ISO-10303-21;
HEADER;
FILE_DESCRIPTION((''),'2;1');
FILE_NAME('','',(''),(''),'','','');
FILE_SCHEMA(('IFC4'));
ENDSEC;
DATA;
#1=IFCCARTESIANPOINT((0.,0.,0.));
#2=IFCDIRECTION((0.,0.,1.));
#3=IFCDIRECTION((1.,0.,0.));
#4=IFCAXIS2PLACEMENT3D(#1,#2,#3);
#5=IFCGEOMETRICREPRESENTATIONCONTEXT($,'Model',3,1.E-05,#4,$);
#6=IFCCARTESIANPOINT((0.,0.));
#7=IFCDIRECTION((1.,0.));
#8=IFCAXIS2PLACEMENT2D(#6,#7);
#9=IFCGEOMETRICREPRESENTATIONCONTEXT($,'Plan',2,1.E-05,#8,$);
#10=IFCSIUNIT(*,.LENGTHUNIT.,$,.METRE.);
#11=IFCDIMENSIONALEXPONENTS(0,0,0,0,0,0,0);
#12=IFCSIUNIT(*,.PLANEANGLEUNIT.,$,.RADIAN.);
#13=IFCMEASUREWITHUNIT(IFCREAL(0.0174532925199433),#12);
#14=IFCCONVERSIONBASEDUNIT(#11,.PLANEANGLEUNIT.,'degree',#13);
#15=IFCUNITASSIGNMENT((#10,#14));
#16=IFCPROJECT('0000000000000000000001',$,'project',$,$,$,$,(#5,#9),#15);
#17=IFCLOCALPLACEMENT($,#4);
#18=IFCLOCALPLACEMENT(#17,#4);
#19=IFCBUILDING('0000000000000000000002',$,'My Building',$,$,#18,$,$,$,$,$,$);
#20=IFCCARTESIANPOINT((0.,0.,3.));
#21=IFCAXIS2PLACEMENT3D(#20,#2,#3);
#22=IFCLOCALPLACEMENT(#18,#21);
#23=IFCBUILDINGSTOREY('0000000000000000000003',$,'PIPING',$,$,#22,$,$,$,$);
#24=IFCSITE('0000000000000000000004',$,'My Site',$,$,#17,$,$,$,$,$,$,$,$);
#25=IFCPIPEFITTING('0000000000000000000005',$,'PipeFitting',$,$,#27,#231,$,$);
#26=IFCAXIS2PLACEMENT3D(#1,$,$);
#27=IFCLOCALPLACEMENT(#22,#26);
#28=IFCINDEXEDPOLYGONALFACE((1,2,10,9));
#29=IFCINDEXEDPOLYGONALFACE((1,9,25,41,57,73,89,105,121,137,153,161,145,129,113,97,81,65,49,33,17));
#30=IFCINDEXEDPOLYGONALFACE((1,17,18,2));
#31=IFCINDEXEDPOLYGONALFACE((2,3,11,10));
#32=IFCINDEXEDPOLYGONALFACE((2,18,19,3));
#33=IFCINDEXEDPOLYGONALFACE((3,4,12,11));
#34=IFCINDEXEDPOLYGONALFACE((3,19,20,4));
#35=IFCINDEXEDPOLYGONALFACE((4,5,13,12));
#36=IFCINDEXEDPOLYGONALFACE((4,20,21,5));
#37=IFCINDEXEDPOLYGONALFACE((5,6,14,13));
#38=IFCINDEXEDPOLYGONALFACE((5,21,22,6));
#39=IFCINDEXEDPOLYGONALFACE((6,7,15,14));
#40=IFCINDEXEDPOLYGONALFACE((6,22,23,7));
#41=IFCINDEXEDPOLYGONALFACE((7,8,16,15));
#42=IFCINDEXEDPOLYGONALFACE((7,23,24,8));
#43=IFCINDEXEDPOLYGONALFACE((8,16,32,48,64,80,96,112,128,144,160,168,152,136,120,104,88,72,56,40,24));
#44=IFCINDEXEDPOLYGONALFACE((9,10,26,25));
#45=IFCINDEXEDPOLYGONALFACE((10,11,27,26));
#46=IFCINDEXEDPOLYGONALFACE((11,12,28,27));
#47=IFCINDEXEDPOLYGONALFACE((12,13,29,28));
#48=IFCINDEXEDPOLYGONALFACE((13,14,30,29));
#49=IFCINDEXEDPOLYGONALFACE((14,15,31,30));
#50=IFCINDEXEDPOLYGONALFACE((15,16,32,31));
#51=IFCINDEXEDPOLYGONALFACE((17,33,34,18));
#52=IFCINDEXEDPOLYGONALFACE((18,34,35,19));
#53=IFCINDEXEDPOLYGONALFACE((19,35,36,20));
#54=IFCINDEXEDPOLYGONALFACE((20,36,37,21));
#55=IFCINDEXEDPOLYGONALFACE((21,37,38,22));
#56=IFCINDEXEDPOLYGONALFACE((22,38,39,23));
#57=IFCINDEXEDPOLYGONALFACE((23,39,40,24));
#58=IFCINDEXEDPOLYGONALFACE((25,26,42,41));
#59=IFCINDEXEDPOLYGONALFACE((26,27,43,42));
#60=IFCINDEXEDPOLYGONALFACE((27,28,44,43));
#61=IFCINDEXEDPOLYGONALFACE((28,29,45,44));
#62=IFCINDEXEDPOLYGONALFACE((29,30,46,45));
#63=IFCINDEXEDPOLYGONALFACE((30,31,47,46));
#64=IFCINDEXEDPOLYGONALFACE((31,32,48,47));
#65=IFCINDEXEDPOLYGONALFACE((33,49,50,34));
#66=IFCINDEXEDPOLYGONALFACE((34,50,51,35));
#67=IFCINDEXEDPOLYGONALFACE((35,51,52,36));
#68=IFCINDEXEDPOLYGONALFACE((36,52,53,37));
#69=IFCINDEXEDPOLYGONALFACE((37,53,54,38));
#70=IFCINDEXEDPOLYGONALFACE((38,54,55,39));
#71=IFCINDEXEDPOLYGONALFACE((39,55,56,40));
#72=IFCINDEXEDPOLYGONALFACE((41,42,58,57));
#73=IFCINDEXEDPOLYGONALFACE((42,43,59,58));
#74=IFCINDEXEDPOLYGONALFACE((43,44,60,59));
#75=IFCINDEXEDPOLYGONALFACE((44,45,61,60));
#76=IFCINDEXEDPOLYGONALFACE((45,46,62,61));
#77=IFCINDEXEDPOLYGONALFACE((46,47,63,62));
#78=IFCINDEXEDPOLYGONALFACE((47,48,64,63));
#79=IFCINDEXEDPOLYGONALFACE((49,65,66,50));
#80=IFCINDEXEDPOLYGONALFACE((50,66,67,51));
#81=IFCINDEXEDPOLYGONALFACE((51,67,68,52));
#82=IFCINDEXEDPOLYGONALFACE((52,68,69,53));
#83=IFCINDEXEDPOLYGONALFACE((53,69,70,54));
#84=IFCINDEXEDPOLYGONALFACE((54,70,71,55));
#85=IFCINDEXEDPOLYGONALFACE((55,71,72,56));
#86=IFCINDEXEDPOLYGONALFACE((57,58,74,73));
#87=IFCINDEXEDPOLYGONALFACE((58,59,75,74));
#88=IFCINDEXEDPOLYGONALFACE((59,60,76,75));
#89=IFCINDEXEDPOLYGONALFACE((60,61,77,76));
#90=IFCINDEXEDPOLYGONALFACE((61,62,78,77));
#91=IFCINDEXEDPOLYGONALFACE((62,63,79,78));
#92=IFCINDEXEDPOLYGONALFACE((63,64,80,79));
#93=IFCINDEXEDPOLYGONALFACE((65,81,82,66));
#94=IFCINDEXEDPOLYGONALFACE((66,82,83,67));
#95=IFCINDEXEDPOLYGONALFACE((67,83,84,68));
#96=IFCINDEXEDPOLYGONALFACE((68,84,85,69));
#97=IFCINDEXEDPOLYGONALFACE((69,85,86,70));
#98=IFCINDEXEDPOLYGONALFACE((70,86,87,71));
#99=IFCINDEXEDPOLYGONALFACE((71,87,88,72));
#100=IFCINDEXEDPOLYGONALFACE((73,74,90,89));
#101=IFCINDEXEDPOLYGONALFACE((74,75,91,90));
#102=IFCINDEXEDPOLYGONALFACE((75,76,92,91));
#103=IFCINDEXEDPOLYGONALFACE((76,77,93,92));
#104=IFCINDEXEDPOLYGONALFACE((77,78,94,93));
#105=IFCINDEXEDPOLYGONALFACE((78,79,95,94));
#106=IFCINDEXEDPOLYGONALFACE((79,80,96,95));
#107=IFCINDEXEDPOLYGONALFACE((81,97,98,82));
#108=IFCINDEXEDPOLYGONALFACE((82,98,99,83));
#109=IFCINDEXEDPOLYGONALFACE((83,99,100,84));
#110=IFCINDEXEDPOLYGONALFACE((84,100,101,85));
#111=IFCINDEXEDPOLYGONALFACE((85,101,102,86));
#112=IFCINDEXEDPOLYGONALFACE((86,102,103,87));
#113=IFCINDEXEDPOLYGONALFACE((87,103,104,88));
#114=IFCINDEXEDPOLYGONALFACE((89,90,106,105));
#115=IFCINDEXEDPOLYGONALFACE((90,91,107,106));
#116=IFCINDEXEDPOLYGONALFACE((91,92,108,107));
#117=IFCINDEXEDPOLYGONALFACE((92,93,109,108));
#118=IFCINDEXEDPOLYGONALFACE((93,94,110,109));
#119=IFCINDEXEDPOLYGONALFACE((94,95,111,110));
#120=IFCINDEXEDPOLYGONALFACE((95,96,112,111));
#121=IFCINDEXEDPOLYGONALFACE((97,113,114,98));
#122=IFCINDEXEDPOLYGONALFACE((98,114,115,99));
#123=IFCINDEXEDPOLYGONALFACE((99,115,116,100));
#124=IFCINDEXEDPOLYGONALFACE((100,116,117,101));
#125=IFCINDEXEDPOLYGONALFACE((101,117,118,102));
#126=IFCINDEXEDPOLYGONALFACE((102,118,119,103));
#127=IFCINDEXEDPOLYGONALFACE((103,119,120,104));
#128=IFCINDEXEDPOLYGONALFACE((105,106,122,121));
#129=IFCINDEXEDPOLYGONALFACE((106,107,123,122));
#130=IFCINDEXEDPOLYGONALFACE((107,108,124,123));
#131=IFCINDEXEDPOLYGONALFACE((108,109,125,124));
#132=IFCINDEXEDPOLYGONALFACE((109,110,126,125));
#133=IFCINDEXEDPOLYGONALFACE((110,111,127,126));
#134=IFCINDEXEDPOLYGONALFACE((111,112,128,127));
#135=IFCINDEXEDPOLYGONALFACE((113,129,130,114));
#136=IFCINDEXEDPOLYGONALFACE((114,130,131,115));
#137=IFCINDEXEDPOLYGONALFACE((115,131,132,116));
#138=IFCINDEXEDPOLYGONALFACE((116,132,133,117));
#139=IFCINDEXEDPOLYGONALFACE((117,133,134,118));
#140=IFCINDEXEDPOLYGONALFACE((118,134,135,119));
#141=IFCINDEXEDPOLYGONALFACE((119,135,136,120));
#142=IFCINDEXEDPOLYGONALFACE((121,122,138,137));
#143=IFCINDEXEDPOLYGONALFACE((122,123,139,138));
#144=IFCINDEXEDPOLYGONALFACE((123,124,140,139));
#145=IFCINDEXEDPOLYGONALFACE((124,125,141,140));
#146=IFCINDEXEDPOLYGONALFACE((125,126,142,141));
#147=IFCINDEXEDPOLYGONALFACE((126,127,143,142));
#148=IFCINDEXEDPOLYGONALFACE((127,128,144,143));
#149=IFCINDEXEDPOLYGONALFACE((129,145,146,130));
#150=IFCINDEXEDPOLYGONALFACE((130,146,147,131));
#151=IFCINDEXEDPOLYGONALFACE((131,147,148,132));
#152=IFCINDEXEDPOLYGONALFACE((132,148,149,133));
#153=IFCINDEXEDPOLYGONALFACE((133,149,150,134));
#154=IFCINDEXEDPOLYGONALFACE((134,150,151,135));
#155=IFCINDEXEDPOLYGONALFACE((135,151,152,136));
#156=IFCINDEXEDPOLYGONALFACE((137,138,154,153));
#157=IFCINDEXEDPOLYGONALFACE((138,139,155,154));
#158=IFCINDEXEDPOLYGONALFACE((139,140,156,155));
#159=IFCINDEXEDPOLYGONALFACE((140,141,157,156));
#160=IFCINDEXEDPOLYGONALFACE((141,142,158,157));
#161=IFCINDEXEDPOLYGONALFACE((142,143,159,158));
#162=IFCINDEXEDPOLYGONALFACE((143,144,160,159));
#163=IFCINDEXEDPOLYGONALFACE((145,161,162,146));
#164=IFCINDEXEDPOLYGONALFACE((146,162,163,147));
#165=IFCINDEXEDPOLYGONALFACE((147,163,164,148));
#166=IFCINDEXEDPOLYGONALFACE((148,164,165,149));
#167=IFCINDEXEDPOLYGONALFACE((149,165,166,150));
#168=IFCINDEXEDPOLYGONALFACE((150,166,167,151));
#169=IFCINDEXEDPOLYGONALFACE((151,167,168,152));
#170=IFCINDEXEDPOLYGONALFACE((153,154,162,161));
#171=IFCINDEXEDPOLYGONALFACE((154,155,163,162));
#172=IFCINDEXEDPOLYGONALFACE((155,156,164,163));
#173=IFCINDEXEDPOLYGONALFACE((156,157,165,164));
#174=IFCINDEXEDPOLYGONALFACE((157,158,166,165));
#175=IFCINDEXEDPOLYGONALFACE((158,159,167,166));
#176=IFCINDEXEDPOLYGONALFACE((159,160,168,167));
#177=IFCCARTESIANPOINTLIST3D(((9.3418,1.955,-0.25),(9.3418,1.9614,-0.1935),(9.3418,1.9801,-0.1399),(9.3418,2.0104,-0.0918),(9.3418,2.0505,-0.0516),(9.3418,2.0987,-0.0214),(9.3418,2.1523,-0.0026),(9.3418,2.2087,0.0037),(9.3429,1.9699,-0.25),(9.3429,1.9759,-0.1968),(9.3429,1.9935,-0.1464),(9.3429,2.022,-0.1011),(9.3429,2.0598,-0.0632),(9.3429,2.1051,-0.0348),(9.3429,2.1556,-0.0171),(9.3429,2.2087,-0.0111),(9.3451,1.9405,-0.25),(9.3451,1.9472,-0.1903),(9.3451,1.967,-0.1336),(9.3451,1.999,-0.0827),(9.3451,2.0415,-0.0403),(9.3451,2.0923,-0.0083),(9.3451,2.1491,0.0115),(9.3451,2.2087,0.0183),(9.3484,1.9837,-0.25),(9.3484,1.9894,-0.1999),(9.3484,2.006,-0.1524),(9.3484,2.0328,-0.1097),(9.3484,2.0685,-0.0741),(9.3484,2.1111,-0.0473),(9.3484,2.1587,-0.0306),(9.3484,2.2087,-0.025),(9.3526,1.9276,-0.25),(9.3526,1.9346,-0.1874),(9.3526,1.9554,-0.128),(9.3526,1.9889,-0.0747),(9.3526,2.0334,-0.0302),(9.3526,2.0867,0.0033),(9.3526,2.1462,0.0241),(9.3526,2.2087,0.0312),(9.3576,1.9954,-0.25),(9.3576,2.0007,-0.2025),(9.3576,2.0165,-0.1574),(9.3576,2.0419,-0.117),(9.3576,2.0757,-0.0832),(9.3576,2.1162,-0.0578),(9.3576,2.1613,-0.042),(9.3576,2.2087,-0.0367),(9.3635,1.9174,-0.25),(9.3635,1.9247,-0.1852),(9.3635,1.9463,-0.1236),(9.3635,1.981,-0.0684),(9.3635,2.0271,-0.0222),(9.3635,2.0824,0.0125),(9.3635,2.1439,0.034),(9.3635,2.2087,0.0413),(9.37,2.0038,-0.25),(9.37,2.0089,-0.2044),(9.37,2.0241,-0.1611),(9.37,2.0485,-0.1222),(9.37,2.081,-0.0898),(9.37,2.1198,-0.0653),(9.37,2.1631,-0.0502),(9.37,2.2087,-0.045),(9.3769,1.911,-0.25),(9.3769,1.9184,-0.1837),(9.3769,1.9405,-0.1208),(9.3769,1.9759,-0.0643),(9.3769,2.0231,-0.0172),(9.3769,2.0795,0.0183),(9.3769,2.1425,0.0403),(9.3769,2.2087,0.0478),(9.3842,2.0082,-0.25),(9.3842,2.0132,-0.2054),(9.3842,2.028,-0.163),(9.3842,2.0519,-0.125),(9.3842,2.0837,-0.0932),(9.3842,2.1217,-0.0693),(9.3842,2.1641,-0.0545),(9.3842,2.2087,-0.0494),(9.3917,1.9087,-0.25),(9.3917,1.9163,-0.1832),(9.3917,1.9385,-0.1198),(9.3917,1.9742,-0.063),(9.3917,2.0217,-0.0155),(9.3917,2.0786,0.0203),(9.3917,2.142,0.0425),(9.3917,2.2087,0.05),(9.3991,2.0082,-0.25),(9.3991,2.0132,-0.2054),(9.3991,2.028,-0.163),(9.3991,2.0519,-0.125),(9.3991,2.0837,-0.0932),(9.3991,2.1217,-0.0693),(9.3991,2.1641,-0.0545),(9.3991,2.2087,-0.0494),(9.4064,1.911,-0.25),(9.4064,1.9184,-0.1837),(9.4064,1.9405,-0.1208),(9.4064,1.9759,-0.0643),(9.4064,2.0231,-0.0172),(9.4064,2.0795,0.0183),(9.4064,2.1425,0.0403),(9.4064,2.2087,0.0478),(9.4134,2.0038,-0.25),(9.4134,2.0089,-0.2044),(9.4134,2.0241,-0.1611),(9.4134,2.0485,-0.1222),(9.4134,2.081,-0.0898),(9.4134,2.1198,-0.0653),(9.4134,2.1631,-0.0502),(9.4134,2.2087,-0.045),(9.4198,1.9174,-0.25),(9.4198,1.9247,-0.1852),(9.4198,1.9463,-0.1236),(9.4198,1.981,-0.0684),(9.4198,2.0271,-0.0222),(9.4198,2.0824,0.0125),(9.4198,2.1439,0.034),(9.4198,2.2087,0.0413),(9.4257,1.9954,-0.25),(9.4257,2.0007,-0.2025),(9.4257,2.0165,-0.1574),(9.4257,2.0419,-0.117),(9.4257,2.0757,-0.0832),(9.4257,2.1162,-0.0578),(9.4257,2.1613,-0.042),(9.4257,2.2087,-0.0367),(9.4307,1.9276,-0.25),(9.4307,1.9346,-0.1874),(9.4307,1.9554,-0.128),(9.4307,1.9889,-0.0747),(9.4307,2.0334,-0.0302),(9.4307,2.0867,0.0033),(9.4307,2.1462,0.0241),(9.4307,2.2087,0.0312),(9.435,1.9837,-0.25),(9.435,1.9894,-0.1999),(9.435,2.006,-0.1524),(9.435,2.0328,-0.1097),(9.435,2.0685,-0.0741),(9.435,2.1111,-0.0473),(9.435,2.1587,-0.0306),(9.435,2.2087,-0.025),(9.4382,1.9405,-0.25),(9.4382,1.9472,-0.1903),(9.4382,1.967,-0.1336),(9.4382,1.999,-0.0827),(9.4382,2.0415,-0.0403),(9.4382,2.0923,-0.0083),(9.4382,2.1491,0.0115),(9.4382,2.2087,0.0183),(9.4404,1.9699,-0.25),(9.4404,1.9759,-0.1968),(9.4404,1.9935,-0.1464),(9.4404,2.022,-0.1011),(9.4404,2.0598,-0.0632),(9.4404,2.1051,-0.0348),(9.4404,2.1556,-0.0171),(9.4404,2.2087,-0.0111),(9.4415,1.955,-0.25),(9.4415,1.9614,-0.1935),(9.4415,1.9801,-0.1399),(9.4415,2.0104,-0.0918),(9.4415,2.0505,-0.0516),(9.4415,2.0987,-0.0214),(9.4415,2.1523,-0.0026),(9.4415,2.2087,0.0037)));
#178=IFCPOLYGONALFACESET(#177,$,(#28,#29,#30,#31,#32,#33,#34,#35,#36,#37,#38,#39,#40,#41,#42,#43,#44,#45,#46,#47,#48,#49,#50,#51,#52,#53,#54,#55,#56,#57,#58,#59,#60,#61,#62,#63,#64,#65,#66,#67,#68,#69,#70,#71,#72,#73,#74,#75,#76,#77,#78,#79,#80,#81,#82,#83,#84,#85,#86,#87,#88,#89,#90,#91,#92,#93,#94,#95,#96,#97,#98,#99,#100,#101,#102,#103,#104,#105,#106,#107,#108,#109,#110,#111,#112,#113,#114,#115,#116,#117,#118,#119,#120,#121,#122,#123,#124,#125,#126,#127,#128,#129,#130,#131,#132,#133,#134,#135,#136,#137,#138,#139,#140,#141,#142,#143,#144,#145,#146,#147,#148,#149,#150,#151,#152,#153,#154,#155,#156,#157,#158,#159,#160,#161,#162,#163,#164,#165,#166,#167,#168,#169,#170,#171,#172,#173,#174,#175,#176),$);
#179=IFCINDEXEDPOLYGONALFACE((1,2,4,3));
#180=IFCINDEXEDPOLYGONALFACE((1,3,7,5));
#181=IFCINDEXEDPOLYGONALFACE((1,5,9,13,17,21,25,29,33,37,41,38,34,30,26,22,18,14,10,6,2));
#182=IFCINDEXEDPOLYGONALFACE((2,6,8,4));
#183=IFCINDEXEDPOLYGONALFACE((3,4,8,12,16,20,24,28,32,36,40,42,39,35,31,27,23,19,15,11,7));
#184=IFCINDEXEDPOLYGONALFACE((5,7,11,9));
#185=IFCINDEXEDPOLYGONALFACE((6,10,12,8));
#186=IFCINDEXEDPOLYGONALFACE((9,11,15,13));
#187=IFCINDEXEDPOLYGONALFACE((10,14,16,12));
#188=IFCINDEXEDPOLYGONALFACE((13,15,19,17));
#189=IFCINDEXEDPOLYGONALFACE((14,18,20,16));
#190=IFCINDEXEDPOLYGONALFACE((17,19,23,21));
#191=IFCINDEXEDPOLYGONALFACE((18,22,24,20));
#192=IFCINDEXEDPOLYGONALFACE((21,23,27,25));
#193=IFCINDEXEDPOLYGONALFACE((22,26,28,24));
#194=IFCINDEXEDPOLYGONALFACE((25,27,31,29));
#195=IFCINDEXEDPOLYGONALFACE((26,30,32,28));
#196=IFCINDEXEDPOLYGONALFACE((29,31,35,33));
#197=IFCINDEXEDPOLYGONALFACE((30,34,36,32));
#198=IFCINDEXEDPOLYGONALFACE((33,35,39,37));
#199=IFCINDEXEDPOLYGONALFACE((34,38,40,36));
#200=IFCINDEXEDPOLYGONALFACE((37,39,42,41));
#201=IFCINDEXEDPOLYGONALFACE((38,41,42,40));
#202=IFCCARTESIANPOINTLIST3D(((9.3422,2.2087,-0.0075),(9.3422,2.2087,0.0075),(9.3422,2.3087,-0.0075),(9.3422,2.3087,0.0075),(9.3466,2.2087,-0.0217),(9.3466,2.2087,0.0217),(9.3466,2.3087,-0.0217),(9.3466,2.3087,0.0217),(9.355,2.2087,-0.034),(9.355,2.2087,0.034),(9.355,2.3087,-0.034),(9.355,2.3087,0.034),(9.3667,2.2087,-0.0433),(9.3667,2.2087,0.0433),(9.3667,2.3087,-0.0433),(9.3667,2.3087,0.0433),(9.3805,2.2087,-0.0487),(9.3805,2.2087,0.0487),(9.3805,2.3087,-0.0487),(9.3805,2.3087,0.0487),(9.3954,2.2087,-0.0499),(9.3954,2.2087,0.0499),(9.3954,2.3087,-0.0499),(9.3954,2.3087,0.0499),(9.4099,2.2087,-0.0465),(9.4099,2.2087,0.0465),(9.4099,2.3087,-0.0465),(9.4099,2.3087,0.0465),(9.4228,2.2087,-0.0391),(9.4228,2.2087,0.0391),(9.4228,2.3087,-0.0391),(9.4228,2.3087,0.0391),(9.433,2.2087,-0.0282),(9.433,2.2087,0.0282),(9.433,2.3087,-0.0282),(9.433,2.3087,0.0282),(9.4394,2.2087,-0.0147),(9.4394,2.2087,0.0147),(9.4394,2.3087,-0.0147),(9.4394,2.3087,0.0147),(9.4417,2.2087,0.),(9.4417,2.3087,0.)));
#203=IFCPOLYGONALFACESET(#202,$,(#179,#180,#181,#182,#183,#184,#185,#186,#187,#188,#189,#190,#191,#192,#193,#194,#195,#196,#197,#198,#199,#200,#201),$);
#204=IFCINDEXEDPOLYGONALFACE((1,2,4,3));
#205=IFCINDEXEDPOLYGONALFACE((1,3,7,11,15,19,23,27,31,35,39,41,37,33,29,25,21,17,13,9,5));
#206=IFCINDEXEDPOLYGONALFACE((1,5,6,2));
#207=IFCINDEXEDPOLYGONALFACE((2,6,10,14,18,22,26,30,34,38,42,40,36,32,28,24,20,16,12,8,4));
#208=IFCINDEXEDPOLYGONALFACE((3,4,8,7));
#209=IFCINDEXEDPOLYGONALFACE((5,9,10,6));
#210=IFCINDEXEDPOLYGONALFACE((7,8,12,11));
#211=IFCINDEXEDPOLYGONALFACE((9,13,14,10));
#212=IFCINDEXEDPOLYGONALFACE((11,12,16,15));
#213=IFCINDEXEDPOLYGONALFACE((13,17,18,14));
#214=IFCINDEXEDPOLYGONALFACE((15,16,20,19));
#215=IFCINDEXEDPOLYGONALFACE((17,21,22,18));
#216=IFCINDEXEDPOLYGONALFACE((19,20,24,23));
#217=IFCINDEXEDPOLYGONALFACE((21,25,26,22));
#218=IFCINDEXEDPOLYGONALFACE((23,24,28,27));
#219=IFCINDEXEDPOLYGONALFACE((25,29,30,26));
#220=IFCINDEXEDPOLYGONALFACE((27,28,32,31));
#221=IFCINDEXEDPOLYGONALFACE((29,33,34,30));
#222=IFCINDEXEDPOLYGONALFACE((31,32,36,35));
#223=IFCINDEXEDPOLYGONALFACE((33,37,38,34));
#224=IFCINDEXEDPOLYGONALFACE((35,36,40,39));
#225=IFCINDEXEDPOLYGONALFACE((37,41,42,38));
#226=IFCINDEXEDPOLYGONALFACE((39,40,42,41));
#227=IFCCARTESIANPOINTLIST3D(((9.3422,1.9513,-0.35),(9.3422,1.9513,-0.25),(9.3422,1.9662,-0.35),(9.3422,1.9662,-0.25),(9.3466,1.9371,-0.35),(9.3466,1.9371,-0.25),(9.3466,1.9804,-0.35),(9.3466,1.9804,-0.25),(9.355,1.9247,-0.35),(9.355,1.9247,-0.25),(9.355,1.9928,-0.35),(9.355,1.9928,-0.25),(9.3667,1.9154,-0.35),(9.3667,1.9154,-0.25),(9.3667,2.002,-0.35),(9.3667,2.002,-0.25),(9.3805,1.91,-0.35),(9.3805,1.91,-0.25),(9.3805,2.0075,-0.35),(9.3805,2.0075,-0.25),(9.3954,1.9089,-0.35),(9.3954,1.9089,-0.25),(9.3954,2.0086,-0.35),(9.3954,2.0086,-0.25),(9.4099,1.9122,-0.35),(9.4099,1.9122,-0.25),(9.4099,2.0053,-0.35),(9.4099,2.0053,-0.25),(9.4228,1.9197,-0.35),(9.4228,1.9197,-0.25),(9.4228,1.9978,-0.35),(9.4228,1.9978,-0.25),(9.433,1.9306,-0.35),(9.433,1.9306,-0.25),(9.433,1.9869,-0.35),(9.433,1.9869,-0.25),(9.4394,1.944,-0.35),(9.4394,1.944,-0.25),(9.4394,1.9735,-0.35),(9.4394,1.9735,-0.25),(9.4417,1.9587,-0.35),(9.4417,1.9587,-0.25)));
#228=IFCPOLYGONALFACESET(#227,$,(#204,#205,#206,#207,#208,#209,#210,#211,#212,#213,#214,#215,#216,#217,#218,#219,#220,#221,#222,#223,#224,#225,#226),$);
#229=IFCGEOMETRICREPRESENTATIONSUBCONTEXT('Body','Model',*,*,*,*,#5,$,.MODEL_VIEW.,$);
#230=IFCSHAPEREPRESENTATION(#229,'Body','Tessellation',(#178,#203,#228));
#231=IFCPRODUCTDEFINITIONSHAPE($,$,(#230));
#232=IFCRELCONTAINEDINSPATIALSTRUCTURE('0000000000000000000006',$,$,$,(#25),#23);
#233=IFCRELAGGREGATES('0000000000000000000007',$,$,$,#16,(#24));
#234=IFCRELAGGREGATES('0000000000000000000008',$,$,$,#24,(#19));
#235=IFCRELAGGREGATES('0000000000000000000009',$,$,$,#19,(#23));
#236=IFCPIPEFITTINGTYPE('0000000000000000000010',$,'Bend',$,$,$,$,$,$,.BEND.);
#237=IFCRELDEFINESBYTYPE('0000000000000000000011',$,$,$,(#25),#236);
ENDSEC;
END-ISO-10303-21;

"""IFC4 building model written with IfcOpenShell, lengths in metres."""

from ifc_helpers import new_model, entity, si_unit, converted_unit, frame, origin_with_axes, origin_2d_with_axis, place, context, subcontext, project, spatial, line, indexed_curve, circle, outline, extrude, source, transform, mapped, type_object, type_shapes, element, save


model = new_model("IFC4")

# Units and contexts
model_context = context("Model", 3, precision=1e-05, world=origin_with_axes())
plan_context = context("Plan", 2, precision=1e-05, world=origin_2d_with_axis())
body_context = subcontext(model_context, "Body", "Model", "MODEL_VIEW")
ifc_project = project(units=[si_unit("LENGTHUNIT", "METRE"), converted_unit("PLANEANGLEUNIT", "degree", entity("IfcReal", 0.0174532925199433), si_unit("PLANEANGLEUNIT", "RADIAN"), dimensions=[0, 0, 0, 0, 0, 0, 0])], contexts=[model_context, plan_context])

# Site, building, storey
site_placement = place(None, origin_with_axes())
site = spatial("IfcSite", under=ifc_project, at=site_placement, Name="My Site")
building_placement = place(site_placement, origin_with_axes())
building = spatial("IfcBuilding", under=site, at=building_placement, Name="My Building")
storey_placement = place(building_placement, frame((0.0, 0.0, 3.0), z_axis=(0.0, 0.0, 1.0), x_axis=(1.0, 0.0, 0.0)))
storey = spatial("IfcBuildingStorey", under=building, at=storey_placement, Name="PIPING")

# Pipe fitting, opening
pipe_fitting_type = type_object("IfcPipeFittingType", Name="Bend", PredefinedType="BEND")
shared_shape = source(origin_with_axes(), body_context, "Body", "SolidModel", [
    entity("IfcSweptDiskSolid", entity("IfcIndexedPolyCurve", entity("IfcCartesianPointList3D", [[0.0, 0.0, 0.1], [0.0, -0.0732, 0.2768], [0.0, -0.25, 0.35]]), [entity("IfcArcIndex", [1, 2, 3])]), 0.05),
    extrude(circle(Radius=0.05), origin_with_axes(), (0.0, 0.0, 1.0), 0.1),
    extrude(circle(Radius=0.05), frame((0.0, -0.25, 0.35), z_axis=(0.0, -1.0, 0.0), x_axis=(1.0, 0.0, 0.0)), (0.0, 0.0, 1.0), 0.1),
])
type_shapes(pipe_fitting_type, [shared_shape])
pipe_fitting_1_placement = place(storey_placement, frame((9.3917, 2.3087, 0.0), z_axis=(0.0, -1.0, 0.0), x_axis=(1.0, 0.0, 0.0)))
pipe_fitting_1 = element("IfcPipeFitting", 1, at=pipe_fitting_1_placement, inside=storey, type_object=pipe_fitting_type, Name="PipeFitting", context=body_context, shape_type="MappedRepresentation", body=[
    mapped(shared_shape, transform((0.0, 0.0, 0.0), x_axis=(1.0, 0.0, 0.0), y_axis=(0.0, 1.0, 0.0), z_axis=(0.0, 0.0, 1.0), scale=1.0)),
])
opening_1_placement = place(pipe_fitting_1_placement, frame((-9.3917, -3.0, 2.3087), z_axis=(0.0, 1.0, 0.0), x_axis=(1.0, 0.0, 0.0)))
element("IfcOpeningElement", 2, at=opening_1_placement, cuts=pipe_fitting_1, PredefinedType="OPENING", context=body_context, shape_type="SweptSolid", body=[
    extrude(outline(indexed_curve([(0.0, 0.0), (0.5, 0.0), (0.5, 0.5), (0.0, 0.5)], segments=[line(1, 2, 3, 4, 1)])), origin_with_axes(), (0.0, 0.0, 1.0), 0.5),
])

save(model, "model.ifc")
